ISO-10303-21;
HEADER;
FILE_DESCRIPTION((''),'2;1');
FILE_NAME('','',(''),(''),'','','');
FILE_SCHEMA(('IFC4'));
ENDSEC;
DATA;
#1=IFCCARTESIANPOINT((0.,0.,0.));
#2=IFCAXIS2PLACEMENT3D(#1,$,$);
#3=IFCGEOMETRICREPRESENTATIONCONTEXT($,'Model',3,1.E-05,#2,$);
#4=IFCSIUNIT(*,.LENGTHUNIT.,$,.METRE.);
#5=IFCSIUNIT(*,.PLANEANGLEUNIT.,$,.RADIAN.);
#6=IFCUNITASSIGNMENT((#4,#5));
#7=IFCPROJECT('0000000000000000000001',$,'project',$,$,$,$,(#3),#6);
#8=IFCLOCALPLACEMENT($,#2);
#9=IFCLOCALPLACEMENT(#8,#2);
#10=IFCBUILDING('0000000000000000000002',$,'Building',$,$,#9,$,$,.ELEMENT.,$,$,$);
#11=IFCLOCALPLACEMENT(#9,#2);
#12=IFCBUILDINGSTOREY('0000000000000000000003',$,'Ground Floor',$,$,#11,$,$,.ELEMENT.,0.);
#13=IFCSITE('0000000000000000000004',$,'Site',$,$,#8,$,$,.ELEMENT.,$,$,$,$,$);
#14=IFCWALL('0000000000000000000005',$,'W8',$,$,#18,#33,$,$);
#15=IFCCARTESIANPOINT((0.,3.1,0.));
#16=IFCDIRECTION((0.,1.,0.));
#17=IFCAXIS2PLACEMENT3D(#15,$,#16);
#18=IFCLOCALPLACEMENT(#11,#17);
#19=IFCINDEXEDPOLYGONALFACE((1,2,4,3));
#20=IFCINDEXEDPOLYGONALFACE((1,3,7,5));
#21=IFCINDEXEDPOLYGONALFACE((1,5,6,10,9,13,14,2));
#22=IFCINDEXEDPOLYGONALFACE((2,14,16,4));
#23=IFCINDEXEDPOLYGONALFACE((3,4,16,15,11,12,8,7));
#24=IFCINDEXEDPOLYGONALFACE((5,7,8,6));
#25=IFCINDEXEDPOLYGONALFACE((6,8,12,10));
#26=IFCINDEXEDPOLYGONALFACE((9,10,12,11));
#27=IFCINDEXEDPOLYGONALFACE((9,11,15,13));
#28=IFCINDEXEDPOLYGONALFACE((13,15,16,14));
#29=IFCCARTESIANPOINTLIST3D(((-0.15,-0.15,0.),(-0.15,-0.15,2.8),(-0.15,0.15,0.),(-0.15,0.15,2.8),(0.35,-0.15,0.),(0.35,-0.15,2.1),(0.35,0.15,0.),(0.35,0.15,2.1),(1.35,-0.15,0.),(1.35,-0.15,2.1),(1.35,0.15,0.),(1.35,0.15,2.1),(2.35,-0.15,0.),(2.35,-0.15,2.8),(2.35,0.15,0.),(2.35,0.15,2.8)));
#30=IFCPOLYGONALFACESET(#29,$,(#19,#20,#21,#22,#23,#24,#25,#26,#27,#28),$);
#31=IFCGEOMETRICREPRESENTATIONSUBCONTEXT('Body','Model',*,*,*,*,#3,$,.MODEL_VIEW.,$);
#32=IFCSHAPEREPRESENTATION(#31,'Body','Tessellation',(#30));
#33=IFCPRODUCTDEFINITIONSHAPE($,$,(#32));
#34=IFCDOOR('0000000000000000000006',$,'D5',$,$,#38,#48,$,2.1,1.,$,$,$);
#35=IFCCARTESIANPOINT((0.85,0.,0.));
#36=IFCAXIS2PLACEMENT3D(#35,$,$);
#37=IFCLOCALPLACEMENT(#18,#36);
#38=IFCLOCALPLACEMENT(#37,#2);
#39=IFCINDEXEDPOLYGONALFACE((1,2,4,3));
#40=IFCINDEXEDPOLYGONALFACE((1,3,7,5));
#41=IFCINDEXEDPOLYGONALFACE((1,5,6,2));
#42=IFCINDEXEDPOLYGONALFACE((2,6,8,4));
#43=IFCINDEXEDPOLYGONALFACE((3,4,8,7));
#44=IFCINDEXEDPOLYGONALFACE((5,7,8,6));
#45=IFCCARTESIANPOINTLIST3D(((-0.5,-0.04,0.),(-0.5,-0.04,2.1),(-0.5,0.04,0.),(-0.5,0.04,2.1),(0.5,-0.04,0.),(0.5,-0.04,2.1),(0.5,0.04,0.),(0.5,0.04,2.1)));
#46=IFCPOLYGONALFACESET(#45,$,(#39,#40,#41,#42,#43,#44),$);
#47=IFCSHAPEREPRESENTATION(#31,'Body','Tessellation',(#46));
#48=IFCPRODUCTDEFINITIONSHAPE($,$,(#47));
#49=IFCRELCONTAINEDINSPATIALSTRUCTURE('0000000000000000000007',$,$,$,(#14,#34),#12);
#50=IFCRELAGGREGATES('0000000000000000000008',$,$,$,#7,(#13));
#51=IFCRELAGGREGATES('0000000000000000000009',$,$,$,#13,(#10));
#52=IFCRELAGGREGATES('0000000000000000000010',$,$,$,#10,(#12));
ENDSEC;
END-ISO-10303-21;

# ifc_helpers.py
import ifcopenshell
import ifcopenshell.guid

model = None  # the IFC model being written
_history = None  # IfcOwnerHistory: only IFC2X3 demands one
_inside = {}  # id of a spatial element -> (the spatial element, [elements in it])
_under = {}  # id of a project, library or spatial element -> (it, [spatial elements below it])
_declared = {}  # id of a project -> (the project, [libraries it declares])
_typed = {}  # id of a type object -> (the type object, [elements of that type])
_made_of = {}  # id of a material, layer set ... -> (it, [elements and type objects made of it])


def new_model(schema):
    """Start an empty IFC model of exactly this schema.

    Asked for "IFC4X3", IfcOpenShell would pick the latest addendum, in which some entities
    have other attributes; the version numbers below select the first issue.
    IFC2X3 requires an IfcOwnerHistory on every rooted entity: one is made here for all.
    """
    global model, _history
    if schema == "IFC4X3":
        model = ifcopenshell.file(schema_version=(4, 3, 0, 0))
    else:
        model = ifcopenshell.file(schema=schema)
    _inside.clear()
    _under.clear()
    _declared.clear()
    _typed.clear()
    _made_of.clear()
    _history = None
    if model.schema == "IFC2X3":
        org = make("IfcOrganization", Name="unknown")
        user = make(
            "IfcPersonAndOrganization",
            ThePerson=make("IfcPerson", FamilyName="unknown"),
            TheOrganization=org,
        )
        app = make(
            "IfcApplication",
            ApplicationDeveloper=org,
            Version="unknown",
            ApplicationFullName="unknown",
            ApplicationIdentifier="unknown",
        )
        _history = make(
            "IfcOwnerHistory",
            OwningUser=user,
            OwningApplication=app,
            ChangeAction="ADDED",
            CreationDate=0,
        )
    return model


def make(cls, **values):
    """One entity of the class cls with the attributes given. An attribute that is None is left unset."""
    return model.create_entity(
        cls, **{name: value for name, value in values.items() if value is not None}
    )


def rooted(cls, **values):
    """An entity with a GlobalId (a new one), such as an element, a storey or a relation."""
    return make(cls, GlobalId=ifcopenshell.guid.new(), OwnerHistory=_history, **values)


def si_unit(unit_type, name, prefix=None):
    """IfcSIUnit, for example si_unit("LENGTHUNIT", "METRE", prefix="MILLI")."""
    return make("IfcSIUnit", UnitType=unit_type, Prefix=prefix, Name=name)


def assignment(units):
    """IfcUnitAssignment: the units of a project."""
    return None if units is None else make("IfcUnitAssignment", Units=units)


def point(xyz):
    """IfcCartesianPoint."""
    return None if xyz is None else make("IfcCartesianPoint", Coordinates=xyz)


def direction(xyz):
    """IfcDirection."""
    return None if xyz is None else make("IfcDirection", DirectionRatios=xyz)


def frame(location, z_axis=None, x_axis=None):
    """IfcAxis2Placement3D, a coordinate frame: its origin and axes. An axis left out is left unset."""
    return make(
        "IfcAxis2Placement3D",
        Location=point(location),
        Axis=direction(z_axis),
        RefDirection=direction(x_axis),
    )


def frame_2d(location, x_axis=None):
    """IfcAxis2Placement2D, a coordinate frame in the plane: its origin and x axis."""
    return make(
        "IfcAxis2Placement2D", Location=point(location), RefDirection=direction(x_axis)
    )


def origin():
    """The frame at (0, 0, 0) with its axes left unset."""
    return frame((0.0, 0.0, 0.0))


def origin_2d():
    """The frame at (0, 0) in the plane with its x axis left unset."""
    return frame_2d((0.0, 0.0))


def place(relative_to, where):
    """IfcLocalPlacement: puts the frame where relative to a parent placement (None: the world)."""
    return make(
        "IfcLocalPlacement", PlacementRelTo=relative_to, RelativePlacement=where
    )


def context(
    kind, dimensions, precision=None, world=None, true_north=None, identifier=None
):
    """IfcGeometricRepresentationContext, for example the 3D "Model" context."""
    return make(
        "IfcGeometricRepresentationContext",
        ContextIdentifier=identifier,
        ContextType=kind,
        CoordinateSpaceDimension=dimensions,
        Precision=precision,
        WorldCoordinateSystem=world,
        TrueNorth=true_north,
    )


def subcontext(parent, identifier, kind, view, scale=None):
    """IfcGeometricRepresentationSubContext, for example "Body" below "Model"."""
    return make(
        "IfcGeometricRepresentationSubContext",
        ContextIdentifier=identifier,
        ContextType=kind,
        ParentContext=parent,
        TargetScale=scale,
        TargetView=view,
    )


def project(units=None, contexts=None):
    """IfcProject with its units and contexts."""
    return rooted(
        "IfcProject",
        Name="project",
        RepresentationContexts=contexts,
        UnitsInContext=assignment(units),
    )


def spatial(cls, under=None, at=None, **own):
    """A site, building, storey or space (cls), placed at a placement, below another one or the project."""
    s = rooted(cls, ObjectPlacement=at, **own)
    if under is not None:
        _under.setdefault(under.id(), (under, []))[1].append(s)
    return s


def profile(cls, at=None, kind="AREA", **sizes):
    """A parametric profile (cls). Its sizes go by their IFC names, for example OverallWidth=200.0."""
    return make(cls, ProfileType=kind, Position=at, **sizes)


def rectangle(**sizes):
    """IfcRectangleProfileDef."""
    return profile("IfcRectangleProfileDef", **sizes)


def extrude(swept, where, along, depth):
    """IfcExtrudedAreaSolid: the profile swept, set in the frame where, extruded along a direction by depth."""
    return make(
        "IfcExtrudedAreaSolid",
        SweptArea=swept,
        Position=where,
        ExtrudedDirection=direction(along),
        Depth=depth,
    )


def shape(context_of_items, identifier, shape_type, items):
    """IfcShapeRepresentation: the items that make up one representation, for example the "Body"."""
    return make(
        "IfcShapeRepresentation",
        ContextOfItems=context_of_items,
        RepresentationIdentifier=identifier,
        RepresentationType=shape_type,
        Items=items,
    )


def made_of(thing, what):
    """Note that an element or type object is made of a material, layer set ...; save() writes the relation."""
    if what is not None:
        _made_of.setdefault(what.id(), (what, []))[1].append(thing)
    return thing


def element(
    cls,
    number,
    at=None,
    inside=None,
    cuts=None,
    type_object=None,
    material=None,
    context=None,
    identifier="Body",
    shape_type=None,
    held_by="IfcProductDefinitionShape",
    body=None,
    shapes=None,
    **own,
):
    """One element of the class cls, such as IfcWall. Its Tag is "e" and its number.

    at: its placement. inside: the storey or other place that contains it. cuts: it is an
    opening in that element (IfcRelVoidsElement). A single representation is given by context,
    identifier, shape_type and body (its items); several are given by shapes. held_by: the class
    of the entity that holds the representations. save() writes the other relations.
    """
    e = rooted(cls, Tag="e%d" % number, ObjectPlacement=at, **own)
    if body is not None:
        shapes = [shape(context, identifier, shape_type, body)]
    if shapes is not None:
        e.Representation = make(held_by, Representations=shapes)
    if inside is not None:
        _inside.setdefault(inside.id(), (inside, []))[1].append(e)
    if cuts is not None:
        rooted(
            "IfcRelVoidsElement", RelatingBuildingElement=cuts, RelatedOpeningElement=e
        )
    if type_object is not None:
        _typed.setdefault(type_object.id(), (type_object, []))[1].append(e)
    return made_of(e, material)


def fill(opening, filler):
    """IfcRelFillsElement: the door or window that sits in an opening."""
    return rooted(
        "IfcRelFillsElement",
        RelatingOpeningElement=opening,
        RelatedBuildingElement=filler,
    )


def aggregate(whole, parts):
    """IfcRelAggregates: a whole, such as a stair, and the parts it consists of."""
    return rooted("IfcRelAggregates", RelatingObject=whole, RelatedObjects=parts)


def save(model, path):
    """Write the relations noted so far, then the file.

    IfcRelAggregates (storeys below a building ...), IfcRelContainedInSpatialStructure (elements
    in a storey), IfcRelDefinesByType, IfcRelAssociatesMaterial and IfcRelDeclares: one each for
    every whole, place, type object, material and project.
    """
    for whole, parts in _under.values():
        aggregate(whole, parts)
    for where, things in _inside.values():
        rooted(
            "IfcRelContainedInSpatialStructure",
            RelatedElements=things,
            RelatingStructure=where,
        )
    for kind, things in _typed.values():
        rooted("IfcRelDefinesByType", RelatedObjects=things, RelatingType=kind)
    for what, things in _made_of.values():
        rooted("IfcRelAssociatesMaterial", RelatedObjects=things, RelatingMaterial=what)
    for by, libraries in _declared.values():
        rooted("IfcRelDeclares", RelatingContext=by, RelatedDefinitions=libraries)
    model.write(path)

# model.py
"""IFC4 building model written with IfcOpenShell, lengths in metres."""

from ifc_helpers import new_model, si_unit, frame, frame_2d, origin, origin_2d, place, context, subcontext, project, spatial, rectangle, extrude, element, fill, save


model = new_model("IFC4")

# Units and contexts
model_context = context("Model", 3, precision=1e-05, world=origin())
body_context = subcontext(model_context, "Body", "Model", "MODEL_VIEW")
ifc_project = project(units=[si_unit("LENGTHUNIT", "METRE"), si_unit("PLANEANGLEUNIT", "RADIAN")], contexts=[model_context])

# Site, building, storey
site_placement = place(None, origin())
site = spatial("IfcSite", under=ifc_project, at=site_placement, Name="Site", CompositionType="ELEMENT")
building_placement = place(site_placement, origin())
building = spatial("IfcBuilding", under=site, at=building_placement, Name="Building", CompositionType="ELEMENT")
storey_placement = place(building_placement, origin())
storey = spatial("IfcBuildingStorey", under=building, at=storey_placement, Name="Ground Floor", CompositionType="ELEMENT", Elevation=0.0)

# Wall, opening, door
wall_1_placement = place(storey_placement, frame((0.0, 3.1, 0.0), x_axis=(0.0, 1.0, 0.0)))
wall_1 = element("IfcWall", 1, at=wall_1_placement, inside=storey, Name="W8", context=body_context, shape_type="SweptSolid", body=[
    extrude(rectangle(XDim=2.5, YDim=0.3, at=frame_2d((1.1, 0.0))), origin(), (0.0, 0.0, 1.0), 2.8),
])
opening_1_placement = place(wall_1_placement, frame((0.85, 0.0, 0.0)))
opening_1 = element("IfcOpeningElement", 2, at=opening_1_placement, cuts=wall_1, context=body_context, shape_type="SweptSolid", body=[
    extrude(rectangle(XDim=1.0, YDim=0.4, at=origin_2d()), origin(), (0.0, 0.0, 1.0), 2.1),
])
door_1_placement = place(opening_1_placement, origin())
door_1 = element("IfcDoor", 3, at=door_1_placement, inside=storey, Name="D5", OverallHeight=2.1, OverallWidth=1.0, context=body_context, shape_type="SweptSolid", body=[
    extrude(rectangle(XDim=1.0, YDim=0.08, at=origin_2d()), origin(), (0.0, 0.0, 1.0), 2.1),
])
fill(opening_1, door_1)

save(model, "model.ifc")
